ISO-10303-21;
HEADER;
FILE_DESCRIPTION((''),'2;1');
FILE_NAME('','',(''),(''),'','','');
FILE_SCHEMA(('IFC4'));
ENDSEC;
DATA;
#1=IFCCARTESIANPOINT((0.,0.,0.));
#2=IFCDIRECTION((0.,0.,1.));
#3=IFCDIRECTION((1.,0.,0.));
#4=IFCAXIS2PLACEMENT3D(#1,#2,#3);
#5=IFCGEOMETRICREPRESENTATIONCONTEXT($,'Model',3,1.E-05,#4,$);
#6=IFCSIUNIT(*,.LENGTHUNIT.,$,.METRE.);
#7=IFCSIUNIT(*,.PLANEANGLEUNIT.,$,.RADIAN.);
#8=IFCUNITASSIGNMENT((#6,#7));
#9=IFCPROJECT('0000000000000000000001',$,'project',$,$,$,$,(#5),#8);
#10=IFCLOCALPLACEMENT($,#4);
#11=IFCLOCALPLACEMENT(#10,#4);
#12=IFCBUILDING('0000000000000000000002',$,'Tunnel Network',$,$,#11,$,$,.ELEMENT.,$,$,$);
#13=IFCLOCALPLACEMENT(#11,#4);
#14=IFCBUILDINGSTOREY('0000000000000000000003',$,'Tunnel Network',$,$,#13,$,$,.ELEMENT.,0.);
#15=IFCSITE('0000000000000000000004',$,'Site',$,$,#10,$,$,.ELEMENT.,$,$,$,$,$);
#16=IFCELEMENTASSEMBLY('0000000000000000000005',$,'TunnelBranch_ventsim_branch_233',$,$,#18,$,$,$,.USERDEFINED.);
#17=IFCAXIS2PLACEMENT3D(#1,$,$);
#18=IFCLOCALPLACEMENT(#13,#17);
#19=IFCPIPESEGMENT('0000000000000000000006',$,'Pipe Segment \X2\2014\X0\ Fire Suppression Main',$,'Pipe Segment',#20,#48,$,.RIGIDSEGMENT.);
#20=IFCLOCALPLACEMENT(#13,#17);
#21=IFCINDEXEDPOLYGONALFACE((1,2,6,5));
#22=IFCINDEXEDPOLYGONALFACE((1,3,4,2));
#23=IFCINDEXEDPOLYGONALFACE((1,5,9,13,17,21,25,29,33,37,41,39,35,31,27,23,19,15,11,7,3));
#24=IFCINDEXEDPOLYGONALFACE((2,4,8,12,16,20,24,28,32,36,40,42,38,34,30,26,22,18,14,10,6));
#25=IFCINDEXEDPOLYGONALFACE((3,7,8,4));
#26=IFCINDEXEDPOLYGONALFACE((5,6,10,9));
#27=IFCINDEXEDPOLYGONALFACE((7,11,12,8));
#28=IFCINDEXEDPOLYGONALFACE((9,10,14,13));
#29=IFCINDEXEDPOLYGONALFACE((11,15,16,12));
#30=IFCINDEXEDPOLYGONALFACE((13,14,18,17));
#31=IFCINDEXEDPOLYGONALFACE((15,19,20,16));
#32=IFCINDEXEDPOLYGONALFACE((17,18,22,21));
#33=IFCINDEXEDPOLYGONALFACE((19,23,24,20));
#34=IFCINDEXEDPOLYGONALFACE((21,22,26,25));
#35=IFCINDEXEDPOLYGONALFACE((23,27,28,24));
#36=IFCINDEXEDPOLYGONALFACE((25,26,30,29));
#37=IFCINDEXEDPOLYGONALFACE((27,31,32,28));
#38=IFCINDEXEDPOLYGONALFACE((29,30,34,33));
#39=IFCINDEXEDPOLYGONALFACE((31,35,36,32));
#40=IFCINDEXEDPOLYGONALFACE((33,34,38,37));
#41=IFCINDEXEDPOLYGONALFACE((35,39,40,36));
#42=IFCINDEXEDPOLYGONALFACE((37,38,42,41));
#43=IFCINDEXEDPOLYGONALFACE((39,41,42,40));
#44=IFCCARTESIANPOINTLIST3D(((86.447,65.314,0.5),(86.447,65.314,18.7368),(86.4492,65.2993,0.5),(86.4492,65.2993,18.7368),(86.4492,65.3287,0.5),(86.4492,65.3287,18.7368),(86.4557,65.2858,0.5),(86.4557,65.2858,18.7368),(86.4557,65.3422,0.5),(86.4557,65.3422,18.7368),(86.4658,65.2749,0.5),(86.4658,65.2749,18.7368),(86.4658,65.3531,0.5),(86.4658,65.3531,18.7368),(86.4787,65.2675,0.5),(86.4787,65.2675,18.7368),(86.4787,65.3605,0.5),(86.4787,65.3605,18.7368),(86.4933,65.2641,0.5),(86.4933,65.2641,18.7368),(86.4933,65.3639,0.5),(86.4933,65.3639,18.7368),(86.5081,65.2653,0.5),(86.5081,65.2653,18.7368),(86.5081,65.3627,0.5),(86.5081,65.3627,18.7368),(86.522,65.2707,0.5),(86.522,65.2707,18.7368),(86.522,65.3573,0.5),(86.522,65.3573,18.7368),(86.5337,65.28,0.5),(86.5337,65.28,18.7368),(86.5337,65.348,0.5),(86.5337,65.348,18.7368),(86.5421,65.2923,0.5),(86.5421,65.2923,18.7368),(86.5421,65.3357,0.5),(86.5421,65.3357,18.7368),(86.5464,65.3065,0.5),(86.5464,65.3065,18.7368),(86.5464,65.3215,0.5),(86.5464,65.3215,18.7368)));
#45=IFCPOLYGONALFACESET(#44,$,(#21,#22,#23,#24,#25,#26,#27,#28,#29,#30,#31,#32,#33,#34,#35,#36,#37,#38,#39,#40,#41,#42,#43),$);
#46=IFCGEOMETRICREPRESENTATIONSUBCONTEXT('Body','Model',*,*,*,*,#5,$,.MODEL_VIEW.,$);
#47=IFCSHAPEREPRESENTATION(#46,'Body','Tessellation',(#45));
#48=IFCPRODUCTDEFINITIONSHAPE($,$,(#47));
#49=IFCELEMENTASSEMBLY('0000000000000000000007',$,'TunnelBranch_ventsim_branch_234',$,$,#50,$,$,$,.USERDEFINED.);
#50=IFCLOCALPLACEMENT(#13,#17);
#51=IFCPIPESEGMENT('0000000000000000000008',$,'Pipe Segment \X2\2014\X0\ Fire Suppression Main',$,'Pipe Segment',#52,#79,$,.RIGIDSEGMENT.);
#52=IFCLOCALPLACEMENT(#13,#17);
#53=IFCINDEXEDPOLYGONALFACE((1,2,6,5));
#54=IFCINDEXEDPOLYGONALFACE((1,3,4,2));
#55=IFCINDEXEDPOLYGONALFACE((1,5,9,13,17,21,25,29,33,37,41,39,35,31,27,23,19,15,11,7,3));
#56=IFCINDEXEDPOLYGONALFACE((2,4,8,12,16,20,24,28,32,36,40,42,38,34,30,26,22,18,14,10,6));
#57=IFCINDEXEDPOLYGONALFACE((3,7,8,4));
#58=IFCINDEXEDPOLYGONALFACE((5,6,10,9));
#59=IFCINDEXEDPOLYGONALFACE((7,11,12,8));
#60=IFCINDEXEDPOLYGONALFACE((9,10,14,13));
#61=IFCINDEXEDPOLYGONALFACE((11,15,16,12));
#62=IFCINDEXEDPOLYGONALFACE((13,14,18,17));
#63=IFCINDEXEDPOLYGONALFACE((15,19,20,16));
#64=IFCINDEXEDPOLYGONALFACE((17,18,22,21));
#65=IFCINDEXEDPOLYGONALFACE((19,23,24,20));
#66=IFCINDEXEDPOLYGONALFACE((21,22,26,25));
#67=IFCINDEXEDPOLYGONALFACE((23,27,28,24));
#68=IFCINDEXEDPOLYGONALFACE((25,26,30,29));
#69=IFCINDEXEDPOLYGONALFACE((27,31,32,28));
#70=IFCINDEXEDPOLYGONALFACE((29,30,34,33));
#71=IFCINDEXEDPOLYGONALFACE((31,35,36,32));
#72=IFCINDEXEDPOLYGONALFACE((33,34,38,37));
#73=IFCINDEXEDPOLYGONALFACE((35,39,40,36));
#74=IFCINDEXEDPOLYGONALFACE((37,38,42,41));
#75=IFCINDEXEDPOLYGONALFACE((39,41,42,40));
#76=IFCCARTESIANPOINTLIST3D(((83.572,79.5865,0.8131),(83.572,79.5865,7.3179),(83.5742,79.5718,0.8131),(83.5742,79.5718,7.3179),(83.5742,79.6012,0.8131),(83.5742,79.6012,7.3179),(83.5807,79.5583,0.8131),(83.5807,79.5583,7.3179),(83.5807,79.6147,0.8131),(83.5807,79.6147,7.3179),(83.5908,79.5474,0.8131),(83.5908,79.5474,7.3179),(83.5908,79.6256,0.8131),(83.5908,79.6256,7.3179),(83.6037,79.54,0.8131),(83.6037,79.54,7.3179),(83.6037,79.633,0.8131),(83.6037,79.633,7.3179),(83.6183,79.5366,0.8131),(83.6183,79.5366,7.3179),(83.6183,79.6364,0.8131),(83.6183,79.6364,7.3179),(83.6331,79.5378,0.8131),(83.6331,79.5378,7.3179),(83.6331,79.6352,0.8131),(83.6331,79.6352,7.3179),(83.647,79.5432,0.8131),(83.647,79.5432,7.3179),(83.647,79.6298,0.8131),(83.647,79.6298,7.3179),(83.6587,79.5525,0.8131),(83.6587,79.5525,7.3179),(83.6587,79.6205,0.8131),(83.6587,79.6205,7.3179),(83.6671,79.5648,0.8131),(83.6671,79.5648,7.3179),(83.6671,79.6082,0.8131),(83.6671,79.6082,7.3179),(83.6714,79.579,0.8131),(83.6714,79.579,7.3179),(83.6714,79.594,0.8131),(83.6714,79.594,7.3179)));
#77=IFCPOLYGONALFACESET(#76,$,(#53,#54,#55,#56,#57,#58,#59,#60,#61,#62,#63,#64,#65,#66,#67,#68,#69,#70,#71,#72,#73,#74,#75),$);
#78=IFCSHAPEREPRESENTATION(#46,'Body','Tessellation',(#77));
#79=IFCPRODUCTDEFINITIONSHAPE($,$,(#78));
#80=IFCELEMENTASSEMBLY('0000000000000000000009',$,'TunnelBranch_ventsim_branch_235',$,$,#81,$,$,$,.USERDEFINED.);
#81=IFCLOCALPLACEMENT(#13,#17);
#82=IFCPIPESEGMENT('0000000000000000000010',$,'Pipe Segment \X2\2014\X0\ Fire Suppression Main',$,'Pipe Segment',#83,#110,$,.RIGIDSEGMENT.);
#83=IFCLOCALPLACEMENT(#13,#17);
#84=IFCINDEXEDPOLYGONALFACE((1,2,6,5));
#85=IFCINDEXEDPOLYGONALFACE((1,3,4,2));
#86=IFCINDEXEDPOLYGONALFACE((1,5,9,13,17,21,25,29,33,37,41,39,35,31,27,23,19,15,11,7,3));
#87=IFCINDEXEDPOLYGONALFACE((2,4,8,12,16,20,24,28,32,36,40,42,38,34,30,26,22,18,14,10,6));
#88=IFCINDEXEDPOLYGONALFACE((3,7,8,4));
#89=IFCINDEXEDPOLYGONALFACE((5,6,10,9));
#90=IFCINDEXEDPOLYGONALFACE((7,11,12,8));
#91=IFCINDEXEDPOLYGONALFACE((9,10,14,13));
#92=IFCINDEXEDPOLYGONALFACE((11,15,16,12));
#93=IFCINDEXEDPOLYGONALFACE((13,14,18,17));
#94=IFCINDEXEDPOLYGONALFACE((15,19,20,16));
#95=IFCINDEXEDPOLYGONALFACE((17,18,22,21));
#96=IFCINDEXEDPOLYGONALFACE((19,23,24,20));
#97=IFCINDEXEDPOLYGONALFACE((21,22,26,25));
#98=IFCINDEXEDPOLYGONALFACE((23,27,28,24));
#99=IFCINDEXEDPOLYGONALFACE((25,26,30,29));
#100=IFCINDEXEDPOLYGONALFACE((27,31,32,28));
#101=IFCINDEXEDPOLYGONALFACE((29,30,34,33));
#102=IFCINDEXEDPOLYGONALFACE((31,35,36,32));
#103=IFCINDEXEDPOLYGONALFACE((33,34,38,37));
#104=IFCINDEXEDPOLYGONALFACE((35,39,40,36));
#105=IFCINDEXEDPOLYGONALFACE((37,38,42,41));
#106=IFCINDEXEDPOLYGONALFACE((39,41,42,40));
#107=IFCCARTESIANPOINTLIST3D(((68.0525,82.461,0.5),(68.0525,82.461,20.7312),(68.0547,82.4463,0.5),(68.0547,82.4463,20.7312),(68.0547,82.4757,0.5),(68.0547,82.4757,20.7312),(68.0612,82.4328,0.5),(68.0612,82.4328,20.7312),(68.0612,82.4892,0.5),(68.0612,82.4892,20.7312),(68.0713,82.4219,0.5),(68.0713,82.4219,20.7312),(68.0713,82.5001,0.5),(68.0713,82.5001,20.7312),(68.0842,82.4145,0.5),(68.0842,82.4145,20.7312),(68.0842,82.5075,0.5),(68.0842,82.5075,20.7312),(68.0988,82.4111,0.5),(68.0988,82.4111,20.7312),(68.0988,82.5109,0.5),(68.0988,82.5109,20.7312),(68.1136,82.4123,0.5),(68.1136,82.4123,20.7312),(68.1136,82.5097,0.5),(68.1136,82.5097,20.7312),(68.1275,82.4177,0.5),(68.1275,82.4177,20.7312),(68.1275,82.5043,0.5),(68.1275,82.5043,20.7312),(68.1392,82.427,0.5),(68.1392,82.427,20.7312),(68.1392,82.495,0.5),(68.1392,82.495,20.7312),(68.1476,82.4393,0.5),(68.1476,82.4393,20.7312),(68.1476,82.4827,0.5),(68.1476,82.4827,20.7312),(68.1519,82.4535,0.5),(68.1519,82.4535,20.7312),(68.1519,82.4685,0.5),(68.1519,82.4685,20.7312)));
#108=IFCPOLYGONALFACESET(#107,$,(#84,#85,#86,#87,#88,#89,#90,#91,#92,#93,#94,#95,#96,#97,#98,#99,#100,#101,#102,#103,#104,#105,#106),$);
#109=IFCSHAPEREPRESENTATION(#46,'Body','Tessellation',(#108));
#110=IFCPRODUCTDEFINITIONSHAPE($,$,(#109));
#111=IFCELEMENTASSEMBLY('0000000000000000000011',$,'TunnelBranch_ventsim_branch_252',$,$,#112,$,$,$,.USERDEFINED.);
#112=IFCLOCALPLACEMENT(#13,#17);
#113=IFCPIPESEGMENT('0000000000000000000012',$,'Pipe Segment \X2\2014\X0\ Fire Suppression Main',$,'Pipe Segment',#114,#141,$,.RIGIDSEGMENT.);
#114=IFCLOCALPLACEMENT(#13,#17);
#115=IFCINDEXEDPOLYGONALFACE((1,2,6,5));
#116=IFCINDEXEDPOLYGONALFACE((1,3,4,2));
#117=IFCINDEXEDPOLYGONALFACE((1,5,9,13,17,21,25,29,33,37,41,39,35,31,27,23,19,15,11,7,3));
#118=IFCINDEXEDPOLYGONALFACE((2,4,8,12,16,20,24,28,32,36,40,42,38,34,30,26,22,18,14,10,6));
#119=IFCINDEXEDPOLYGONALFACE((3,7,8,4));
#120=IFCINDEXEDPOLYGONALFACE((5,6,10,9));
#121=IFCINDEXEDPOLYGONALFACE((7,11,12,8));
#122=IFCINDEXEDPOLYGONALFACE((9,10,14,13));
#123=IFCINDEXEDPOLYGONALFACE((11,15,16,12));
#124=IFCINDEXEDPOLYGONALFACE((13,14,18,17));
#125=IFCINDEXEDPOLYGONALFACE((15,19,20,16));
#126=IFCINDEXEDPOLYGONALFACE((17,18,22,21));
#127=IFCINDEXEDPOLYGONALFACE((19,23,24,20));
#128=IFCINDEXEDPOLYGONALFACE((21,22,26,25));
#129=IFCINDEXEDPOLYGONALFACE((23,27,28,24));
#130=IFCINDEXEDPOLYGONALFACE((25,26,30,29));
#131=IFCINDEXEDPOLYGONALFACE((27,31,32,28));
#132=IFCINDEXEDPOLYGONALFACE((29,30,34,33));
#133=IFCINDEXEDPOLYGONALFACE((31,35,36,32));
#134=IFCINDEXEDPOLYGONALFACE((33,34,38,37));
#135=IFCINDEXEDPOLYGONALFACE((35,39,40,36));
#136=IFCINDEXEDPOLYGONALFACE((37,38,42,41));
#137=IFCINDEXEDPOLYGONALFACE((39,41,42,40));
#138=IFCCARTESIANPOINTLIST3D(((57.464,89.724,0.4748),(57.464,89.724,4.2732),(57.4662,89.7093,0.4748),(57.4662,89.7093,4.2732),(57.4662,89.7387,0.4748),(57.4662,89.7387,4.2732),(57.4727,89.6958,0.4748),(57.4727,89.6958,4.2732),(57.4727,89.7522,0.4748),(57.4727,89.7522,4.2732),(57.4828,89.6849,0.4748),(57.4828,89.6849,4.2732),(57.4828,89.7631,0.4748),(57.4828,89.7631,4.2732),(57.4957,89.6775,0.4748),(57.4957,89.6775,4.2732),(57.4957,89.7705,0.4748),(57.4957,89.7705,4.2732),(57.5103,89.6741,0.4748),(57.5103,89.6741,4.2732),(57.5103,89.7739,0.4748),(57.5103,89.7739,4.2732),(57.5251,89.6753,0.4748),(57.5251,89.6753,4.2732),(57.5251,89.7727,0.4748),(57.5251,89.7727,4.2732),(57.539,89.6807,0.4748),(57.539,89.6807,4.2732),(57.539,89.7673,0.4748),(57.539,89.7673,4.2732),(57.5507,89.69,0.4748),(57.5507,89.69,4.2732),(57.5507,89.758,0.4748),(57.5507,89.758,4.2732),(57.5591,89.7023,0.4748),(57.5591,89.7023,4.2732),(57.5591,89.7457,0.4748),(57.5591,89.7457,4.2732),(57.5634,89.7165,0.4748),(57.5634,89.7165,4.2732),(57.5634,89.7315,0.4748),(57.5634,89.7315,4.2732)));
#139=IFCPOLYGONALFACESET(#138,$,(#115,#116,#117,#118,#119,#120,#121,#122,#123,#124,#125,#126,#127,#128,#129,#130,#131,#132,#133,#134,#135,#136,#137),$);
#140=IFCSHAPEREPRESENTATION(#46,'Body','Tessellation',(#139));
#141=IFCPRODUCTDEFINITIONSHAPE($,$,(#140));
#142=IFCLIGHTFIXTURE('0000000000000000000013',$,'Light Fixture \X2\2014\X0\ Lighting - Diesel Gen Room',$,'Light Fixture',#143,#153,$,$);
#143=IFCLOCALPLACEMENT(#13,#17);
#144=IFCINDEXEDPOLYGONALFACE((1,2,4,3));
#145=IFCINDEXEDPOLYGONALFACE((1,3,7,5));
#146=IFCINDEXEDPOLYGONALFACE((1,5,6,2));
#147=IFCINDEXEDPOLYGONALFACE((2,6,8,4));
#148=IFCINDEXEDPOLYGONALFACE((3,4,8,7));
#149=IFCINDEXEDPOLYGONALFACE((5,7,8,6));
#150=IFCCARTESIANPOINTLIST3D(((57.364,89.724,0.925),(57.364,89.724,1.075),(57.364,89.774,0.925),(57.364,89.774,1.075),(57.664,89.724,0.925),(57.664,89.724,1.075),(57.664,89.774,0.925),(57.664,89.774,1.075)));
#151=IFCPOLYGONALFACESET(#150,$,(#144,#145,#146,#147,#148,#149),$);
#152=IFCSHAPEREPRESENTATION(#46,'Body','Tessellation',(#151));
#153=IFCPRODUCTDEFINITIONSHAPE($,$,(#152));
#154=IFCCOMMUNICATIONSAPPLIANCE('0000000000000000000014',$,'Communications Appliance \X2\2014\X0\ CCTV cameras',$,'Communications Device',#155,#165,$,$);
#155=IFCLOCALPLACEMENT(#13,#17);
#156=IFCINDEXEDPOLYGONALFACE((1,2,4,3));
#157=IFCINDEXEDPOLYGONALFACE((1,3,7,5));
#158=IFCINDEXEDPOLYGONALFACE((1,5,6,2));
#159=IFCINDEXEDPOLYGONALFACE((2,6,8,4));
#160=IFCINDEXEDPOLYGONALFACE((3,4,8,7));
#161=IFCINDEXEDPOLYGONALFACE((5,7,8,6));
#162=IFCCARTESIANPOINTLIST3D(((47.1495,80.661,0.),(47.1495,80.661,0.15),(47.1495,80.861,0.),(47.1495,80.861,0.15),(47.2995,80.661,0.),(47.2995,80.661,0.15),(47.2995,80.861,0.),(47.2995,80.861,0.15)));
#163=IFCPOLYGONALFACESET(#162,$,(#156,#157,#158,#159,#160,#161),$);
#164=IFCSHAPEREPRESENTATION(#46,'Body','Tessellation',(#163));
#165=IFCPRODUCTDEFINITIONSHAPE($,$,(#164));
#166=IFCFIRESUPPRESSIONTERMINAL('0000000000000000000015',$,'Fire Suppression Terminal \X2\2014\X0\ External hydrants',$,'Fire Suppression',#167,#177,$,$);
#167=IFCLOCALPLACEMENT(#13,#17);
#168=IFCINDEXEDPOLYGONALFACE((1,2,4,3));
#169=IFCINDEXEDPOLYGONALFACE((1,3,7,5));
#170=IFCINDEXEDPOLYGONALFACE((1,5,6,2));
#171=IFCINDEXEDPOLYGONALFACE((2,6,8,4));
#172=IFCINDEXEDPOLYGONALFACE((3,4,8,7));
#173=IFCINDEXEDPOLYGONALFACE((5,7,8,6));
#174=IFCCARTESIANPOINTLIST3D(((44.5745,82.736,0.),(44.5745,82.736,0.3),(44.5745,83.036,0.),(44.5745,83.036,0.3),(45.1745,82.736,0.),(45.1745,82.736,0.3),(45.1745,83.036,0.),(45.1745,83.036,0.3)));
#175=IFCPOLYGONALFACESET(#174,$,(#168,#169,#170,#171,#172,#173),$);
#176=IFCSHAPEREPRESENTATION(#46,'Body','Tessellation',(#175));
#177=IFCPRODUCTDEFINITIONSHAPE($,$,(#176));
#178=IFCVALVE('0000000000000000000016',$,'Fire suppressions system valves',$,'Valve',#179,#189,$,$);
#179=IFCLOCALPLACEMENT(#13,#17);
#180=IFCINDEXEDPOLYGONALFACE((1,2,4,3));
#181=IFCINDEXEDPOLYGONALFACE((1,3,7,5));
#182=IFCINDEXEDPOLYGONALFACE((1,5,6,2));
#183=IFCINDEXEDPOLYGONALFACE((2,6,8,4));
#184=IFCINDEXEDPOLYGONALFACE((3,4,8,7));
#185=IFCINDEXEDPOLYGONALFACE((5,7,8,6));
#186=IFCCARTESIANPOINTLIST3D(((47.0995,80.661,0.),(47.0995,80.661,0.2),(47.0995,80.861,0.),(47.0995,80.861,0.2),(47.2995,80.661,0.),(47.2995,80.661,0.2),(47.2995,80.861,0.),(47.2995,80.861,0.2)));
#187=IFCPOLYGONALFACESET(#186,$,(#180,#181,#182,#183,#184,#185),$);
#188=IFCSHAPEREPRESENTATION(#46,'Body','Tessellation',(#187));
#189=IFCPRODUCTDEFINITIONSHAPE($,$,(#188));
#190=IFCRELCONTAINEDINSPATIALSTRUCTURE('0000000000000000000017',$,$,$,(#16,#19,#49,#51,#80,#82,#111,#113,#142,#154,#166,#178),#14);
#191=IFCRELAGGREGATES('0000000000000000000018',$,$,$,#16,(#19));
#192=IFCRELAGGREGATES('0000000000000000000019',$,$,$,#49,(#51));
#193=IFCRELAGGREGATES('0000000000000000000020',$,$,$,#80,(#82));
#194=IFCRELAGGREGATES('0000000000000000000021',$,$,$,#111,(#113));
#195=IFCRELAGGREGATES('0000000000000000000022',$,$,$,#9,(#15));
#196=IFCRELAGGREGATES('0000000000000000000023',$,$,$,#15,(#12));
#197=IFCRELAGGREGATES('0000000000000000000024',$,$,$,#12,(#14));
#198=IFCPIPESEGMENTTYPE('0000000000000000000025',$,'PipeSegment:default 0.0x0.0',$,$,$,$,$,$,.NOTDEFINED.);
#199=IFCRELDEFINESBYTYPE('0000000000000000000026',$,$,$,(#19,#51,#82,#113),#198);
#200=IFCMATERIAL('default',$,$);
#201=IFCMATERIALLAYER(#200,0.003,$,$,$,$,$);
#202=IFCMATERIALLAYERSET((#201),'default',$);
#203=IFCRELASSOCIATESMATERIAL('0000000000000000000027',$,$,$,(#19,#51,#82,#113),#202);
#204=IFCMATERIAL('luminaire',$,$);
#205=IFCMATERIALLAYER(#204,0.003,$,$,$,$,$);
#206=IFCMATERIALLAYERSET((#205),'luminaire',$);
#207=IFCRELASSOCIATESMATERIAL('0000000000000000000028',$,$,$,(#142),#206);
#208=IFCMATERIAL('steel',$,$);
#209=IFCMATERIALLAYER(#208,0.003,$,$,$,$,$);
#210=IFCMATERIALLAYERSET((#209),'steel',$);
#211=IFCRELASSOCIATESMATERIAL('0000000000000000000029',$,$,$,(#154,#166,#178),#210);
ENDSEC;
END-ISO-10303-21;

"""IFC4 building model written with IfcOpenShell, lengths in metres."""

from ifc_helpers import new_model, si_unit, frame, origin_with_axes, origin_2d_with_axis, place, context, subcontext, project, spatial, rectangle, circle, extrude, material, layer, layer_set, layer_usage, type_object, element, aggregate, save


model = new_model("IFC4")

# Units and contexts
model_context = context("Model", 3, precision=1e-05, world=origin_with_axes())
body_context = subcontext(model_context, "Body", "Model", "MODEL_VIEW")
ifc_project = project(units=[si_unit("LENGTHUNIT", "METRE"), si_unit("PLANEANGLEUNIT", "RADIAN")], contexts=[model_context])

# Site, building, storey
site_placement = place(None, origin_with_axes())
site = spatial("IfcSite", under=ifc_project, at=site_placement, Name="Site", CompositionType="ELEMENT")
building_placement = place(site_placement, origin_with_axes())
building = spatial("IfcBuilding", under=site, at=building_placement, Name="Tunnel Network", CompositionType="ELEMENT")
storey_placement = place(building_placement, origin_with_axes())
storey = spatial("IfcBuildingStorey", under=building, at=storey_placement, Name="Tunnel Network", CompositionType="ELEMENT", Elevation=0.0)

# Shared definitions
ifc_material_1 = material(Name="steel")
ifc_layer_1 = layer(ifc_material_1, 0.003)
ifc_layer_set_1 = layer_set([ifc_layer_1], Name="steel")

# Element assemblies, pipe segments
ifc_material_2 = material(Name="default")
ifc_layer_2 = layer(ifc_material_2, 0.003)
ifc_layer_set_2 = layer_set([ifc_layer_2], Name="default")
pipe_segment_type_1 = type_object("IfcPipeSegmentType", Name="PipeSegment:default 0.0x0.0")
assembly_1_placement = place(storey_placement, frame((86.497, 65.314, 1.25), z_axis=(0.0, 1.0, 0.0), x_axis=(-1.0, 0.0, 0.0)))
assembly_1 = element("IfcElementAssembly", 1, at=assembly_1_placement, inside=storey, Name="TunnelBranch_ventsim_branch_233", PredefinedType="USERDEFINED")
ifc_layer_usage_1 = layer_usage(ifc_layer_set_2, "AXIS2", "POSITIVE", 0.0)
pipe_segment_1_placement = place(storey_placement, frame((86.497, 65.314, 0.5), z_axis=(0.0, 0.0, 1.0), x_axis=(-1.0, 0.0, 0.0)))
pipe_segment_1 = element("IfcPipeSegment", 2, at=pipe_segment_1_placement, inside=storey, type_object=pipe_segment_type_1, material=ifc_layer_usage_1, Name="Pipe Segment — Fire Suppression Main", ObjectType="Pipe Segment", PredefinedType="RIGIDSEGMENT", context=body_context, shape_type="SweptSolid", body=[
    extrude(circle(Radius=0.05, at=origin_2d_with_axis()), origin_with_axes(), (0.0, 0.0, 1.0), 18.2368),
])
aggregate(assembly_1, [pipe_segment_1])
assembly_2_placement = place(storey_placement, frame((83.622, 79.5865, 1.25), z_axis=(0.0, 1.0, 0.0), x_axis=(-1.0, 0.0, 0.0)))
assembly_2 = element("IfcElementAssembly", 3, at=assembly_2_placement, inside=storey, Name="TunnelBranch_ventsim_branch_234", PredefinedType="USERDEFINED")
ifc_layer_usage_2 = layer_usage(ifc_layer_set_2, "AXIS2", "POSITIVE", 0.0)
pipe_segment_2_placement = place(storey_placement, frame((83.622, 79.5865, 0.8131), z_axis=(0.0, 0.0, 1.0), x_axis=(-1.0, 0.0, 0.0)))
pipe_segment_2 = element("IfcPipeSegment", 4, at=pipe_segment_2_placement, inside=storey, type_object=pipe_segment_type_1, material=ifc_layer_usage_2, Name="Pipe Segment — Fire Suppression Main", ObjectType="Pipe Segment", PredefinedType="RIGIDSEGMENT", context=body_context, shape_type="SweptSolid", body=[
    extrude(circle(Radius=0.05, at=origin_2d_with_axis()), origin_with_axes(), (0.0, 0.0, 1.0), 6.5048),
])
aggregate(assembly_2, [pipe_segment_2])
assembly_3_placement = place(storey_placement, frame((68.1025, 82.461, 1.0), z_axis=(0.0, 1.0, 0.0), x_axis=(-1.0, 0.0, 0.0)))
assembly_3 = element("IfcElementAssembly", 5, at=assembly_3_placement, inside=storey, Name="TunnelBranch_ventsim_branch_235", PredefinedType="USERDEFINED")
ifc_layer_usage_3 = layer_usage(ifc_layer_set_2, "AXIS2", "POSITIVE", 0.0)
pipe_segment_3_placement = place(storey_placement, frame((68.1025, 82.461, 0.5), z_axis=(0.0, 0.0, 1.0), x_axis=(-1.0, 0.0, 0.0)))
pipe_segment_3 = element("IfcPipeSegment", 6, at=pipe_segment_3_placement, inside=storey, type_object=pipe_segment_type_1, material=ifc_layer_usage_3, Name="Pipe Segment — Fire Suppression Main", ObjectType="Pipe Segment", PredefinedType="RIGIDSEGMENT", context=body_context, shape_type="SweptSolid", body=[
    extrude(circle(Radius=0.05, at=origin_2d_with_axis()), origin_with_axes(), (0.0, 0.0, 1.0), 20.2312),
])
assembly_4_placement = place(storey_placement, frame((57.514, 89.724, 1.0), z_axis=(0.0, 1.0, 0.0), x_axis=(-1.0, 0.0, 0.0)))
assembly_4 = element("IfcElementAssembly", 7, at=assembly_4_placement, inside=storey, Name="TunnelBranch_ventsim_branch_252", PredefinedType="USERDEFINED")
ifc_layer_usage_4 = layer_usage(ifc_layer_set_2, "AXIS2", "POSITIVE", 0.0)
pipe_segment_4_placement = place(storey_placement, frame((57.514, 89.724, 0.4748), z_axis=(0.0, 0.0, 1.0), x_axis=(-1.0, 0.0, 0.0)))
pipe_segment_4 = element("IfcPipeSegment", 8, at=pipe_segment_4_placement, inside=storey, type_object=pipe_segment_type_1, material=ifc_layer_usage_4, Name="Pipe Segment — Fire Suppression Main", ObjectType="Pipe Segment", PredefinedType="RIGIDSEGMENT", context=body_context, shape_type="SweptSolid", body=[
    extrude(circle(Radius=0.05, at=origin_2d_with_axis()), origin_with_axes(), (0.0, 0.0, 1.0), 3.7984),
])

# Light fixture
ifc_material_3 = material(Name="luminaire")
ifc_layer_3 = layer(ifc_material_3, 0.003)
ifc_layer_set_3 = layer_set([ifc_layer_3], Name="luminaire")
ifc_layer_usage_5 = layer_usage(ifc_layer_set_3, "AXIS2", "POSITIVE", 0.0)
light_fixture_1_placement = place(storey_placement, frame((57.514, 89.724, 1.0), z_axis=(0.0, 1.0, 0.0), x_axis=(-1.0, 0.0, 0.0)))
element("IfcLightFixture", 9, at=light_fixture_1_placement, inside=storey, material=ifc_layer_usage_5, Name="Light Fixture — Lighting - Diesel Gen Room", ObjectType="Light Fixture", context=body_context, shape_type="SweptSolid", body=[
    extrude(rectangle(XDim=0.3, YDim=0.15, at=origin_2d_with_axis()), origin_with_axes(), (0.0, 0.0, 1.0), 0.05),
])

# Communications appliance
ifc_layer_usage_6 = layer_usage(ifc_layer_set_1, "AXIS2", "POSITIVE", 0.0)
communications_appliance_placement = place(storey_placement, frame((47.2995, 80.761, 0.075), z_axis=(-1.0, 0.0, 0.0), x_axis=(0.0, 1.0, 0.0)))
element("IfcCommunicationsAppliance", 10, at=communications_appliance_placement, inside=storey, material=ifc_layer_usage_6, Name="Communications Appliance — CCTV cameras", ObjectType="Communications Device", context=body_context, shape_type="SweptSolid", body=[
    extrude(rectangle(XDim=0.2, YDim=0.15, at=origin_2d_with_axis()), origin_with_axes(), (0.0, 0.0, 1.0), 0.15),
])

# Fire suppression terminal
ifc_layer_usage_7 = layer_usage(ifc_layer_set_1, "AXIS2", "POSITIVE", 0.0)
fire_suppression_terminal_placement = place(storey_placement, frame((45.1745, 82.886, 0.15), z_axis=(-1.0, 0.0, 0.0), x_axis=(0.0, 1.0, 0.0)))
element("IfcFireSuppressionTerminal", 11, at=fire_suppression_terminal_placement, inside=storey, material=ifc_layer_usage_7, Name="Fire Suppression Terminal — External hydrants", ObjectType="Fire Suppression", context=body_context, shape_type="SweptSolid", body=[
    extrude(rectangle(XDim=0.3, YDim=0.3, at=origin_2d_with_axis()), origin_with_axes(), (0.0, 0.0, 1.0), 0.6),
])

# Valve
ifc_layer_usage_8 = layer_usage(ifc_layer_set_1, "AXIS2", "POSITIVE", 0.0)
valve_placement = place(storey_placement, frame((47.2995, 80.761, 0.1), z_axis=(-1.0, 0.0, 0.0), x_axis=(0.0, 1.0, 0.0)))
element("IfcValve", 12, at=valve_placement, inside=storey, material=ifc_layer_usage_8, Name="Fire suppressions system valves", ObjectType="Valve", context=body_context, shape_type="SweptSolid", body=[
    extrude(rectangle(XDim=0.2, YDim=0.2, at=origin_2d_with_axis()), origin_with_axes(), (0.0, 0.0, 1.0), 0.2),
])

aggregate(assembly_3, [pipe_segment_3])
aggregate(assembly_4, [pipe_segment_4])

save(model, "model.ifc")
